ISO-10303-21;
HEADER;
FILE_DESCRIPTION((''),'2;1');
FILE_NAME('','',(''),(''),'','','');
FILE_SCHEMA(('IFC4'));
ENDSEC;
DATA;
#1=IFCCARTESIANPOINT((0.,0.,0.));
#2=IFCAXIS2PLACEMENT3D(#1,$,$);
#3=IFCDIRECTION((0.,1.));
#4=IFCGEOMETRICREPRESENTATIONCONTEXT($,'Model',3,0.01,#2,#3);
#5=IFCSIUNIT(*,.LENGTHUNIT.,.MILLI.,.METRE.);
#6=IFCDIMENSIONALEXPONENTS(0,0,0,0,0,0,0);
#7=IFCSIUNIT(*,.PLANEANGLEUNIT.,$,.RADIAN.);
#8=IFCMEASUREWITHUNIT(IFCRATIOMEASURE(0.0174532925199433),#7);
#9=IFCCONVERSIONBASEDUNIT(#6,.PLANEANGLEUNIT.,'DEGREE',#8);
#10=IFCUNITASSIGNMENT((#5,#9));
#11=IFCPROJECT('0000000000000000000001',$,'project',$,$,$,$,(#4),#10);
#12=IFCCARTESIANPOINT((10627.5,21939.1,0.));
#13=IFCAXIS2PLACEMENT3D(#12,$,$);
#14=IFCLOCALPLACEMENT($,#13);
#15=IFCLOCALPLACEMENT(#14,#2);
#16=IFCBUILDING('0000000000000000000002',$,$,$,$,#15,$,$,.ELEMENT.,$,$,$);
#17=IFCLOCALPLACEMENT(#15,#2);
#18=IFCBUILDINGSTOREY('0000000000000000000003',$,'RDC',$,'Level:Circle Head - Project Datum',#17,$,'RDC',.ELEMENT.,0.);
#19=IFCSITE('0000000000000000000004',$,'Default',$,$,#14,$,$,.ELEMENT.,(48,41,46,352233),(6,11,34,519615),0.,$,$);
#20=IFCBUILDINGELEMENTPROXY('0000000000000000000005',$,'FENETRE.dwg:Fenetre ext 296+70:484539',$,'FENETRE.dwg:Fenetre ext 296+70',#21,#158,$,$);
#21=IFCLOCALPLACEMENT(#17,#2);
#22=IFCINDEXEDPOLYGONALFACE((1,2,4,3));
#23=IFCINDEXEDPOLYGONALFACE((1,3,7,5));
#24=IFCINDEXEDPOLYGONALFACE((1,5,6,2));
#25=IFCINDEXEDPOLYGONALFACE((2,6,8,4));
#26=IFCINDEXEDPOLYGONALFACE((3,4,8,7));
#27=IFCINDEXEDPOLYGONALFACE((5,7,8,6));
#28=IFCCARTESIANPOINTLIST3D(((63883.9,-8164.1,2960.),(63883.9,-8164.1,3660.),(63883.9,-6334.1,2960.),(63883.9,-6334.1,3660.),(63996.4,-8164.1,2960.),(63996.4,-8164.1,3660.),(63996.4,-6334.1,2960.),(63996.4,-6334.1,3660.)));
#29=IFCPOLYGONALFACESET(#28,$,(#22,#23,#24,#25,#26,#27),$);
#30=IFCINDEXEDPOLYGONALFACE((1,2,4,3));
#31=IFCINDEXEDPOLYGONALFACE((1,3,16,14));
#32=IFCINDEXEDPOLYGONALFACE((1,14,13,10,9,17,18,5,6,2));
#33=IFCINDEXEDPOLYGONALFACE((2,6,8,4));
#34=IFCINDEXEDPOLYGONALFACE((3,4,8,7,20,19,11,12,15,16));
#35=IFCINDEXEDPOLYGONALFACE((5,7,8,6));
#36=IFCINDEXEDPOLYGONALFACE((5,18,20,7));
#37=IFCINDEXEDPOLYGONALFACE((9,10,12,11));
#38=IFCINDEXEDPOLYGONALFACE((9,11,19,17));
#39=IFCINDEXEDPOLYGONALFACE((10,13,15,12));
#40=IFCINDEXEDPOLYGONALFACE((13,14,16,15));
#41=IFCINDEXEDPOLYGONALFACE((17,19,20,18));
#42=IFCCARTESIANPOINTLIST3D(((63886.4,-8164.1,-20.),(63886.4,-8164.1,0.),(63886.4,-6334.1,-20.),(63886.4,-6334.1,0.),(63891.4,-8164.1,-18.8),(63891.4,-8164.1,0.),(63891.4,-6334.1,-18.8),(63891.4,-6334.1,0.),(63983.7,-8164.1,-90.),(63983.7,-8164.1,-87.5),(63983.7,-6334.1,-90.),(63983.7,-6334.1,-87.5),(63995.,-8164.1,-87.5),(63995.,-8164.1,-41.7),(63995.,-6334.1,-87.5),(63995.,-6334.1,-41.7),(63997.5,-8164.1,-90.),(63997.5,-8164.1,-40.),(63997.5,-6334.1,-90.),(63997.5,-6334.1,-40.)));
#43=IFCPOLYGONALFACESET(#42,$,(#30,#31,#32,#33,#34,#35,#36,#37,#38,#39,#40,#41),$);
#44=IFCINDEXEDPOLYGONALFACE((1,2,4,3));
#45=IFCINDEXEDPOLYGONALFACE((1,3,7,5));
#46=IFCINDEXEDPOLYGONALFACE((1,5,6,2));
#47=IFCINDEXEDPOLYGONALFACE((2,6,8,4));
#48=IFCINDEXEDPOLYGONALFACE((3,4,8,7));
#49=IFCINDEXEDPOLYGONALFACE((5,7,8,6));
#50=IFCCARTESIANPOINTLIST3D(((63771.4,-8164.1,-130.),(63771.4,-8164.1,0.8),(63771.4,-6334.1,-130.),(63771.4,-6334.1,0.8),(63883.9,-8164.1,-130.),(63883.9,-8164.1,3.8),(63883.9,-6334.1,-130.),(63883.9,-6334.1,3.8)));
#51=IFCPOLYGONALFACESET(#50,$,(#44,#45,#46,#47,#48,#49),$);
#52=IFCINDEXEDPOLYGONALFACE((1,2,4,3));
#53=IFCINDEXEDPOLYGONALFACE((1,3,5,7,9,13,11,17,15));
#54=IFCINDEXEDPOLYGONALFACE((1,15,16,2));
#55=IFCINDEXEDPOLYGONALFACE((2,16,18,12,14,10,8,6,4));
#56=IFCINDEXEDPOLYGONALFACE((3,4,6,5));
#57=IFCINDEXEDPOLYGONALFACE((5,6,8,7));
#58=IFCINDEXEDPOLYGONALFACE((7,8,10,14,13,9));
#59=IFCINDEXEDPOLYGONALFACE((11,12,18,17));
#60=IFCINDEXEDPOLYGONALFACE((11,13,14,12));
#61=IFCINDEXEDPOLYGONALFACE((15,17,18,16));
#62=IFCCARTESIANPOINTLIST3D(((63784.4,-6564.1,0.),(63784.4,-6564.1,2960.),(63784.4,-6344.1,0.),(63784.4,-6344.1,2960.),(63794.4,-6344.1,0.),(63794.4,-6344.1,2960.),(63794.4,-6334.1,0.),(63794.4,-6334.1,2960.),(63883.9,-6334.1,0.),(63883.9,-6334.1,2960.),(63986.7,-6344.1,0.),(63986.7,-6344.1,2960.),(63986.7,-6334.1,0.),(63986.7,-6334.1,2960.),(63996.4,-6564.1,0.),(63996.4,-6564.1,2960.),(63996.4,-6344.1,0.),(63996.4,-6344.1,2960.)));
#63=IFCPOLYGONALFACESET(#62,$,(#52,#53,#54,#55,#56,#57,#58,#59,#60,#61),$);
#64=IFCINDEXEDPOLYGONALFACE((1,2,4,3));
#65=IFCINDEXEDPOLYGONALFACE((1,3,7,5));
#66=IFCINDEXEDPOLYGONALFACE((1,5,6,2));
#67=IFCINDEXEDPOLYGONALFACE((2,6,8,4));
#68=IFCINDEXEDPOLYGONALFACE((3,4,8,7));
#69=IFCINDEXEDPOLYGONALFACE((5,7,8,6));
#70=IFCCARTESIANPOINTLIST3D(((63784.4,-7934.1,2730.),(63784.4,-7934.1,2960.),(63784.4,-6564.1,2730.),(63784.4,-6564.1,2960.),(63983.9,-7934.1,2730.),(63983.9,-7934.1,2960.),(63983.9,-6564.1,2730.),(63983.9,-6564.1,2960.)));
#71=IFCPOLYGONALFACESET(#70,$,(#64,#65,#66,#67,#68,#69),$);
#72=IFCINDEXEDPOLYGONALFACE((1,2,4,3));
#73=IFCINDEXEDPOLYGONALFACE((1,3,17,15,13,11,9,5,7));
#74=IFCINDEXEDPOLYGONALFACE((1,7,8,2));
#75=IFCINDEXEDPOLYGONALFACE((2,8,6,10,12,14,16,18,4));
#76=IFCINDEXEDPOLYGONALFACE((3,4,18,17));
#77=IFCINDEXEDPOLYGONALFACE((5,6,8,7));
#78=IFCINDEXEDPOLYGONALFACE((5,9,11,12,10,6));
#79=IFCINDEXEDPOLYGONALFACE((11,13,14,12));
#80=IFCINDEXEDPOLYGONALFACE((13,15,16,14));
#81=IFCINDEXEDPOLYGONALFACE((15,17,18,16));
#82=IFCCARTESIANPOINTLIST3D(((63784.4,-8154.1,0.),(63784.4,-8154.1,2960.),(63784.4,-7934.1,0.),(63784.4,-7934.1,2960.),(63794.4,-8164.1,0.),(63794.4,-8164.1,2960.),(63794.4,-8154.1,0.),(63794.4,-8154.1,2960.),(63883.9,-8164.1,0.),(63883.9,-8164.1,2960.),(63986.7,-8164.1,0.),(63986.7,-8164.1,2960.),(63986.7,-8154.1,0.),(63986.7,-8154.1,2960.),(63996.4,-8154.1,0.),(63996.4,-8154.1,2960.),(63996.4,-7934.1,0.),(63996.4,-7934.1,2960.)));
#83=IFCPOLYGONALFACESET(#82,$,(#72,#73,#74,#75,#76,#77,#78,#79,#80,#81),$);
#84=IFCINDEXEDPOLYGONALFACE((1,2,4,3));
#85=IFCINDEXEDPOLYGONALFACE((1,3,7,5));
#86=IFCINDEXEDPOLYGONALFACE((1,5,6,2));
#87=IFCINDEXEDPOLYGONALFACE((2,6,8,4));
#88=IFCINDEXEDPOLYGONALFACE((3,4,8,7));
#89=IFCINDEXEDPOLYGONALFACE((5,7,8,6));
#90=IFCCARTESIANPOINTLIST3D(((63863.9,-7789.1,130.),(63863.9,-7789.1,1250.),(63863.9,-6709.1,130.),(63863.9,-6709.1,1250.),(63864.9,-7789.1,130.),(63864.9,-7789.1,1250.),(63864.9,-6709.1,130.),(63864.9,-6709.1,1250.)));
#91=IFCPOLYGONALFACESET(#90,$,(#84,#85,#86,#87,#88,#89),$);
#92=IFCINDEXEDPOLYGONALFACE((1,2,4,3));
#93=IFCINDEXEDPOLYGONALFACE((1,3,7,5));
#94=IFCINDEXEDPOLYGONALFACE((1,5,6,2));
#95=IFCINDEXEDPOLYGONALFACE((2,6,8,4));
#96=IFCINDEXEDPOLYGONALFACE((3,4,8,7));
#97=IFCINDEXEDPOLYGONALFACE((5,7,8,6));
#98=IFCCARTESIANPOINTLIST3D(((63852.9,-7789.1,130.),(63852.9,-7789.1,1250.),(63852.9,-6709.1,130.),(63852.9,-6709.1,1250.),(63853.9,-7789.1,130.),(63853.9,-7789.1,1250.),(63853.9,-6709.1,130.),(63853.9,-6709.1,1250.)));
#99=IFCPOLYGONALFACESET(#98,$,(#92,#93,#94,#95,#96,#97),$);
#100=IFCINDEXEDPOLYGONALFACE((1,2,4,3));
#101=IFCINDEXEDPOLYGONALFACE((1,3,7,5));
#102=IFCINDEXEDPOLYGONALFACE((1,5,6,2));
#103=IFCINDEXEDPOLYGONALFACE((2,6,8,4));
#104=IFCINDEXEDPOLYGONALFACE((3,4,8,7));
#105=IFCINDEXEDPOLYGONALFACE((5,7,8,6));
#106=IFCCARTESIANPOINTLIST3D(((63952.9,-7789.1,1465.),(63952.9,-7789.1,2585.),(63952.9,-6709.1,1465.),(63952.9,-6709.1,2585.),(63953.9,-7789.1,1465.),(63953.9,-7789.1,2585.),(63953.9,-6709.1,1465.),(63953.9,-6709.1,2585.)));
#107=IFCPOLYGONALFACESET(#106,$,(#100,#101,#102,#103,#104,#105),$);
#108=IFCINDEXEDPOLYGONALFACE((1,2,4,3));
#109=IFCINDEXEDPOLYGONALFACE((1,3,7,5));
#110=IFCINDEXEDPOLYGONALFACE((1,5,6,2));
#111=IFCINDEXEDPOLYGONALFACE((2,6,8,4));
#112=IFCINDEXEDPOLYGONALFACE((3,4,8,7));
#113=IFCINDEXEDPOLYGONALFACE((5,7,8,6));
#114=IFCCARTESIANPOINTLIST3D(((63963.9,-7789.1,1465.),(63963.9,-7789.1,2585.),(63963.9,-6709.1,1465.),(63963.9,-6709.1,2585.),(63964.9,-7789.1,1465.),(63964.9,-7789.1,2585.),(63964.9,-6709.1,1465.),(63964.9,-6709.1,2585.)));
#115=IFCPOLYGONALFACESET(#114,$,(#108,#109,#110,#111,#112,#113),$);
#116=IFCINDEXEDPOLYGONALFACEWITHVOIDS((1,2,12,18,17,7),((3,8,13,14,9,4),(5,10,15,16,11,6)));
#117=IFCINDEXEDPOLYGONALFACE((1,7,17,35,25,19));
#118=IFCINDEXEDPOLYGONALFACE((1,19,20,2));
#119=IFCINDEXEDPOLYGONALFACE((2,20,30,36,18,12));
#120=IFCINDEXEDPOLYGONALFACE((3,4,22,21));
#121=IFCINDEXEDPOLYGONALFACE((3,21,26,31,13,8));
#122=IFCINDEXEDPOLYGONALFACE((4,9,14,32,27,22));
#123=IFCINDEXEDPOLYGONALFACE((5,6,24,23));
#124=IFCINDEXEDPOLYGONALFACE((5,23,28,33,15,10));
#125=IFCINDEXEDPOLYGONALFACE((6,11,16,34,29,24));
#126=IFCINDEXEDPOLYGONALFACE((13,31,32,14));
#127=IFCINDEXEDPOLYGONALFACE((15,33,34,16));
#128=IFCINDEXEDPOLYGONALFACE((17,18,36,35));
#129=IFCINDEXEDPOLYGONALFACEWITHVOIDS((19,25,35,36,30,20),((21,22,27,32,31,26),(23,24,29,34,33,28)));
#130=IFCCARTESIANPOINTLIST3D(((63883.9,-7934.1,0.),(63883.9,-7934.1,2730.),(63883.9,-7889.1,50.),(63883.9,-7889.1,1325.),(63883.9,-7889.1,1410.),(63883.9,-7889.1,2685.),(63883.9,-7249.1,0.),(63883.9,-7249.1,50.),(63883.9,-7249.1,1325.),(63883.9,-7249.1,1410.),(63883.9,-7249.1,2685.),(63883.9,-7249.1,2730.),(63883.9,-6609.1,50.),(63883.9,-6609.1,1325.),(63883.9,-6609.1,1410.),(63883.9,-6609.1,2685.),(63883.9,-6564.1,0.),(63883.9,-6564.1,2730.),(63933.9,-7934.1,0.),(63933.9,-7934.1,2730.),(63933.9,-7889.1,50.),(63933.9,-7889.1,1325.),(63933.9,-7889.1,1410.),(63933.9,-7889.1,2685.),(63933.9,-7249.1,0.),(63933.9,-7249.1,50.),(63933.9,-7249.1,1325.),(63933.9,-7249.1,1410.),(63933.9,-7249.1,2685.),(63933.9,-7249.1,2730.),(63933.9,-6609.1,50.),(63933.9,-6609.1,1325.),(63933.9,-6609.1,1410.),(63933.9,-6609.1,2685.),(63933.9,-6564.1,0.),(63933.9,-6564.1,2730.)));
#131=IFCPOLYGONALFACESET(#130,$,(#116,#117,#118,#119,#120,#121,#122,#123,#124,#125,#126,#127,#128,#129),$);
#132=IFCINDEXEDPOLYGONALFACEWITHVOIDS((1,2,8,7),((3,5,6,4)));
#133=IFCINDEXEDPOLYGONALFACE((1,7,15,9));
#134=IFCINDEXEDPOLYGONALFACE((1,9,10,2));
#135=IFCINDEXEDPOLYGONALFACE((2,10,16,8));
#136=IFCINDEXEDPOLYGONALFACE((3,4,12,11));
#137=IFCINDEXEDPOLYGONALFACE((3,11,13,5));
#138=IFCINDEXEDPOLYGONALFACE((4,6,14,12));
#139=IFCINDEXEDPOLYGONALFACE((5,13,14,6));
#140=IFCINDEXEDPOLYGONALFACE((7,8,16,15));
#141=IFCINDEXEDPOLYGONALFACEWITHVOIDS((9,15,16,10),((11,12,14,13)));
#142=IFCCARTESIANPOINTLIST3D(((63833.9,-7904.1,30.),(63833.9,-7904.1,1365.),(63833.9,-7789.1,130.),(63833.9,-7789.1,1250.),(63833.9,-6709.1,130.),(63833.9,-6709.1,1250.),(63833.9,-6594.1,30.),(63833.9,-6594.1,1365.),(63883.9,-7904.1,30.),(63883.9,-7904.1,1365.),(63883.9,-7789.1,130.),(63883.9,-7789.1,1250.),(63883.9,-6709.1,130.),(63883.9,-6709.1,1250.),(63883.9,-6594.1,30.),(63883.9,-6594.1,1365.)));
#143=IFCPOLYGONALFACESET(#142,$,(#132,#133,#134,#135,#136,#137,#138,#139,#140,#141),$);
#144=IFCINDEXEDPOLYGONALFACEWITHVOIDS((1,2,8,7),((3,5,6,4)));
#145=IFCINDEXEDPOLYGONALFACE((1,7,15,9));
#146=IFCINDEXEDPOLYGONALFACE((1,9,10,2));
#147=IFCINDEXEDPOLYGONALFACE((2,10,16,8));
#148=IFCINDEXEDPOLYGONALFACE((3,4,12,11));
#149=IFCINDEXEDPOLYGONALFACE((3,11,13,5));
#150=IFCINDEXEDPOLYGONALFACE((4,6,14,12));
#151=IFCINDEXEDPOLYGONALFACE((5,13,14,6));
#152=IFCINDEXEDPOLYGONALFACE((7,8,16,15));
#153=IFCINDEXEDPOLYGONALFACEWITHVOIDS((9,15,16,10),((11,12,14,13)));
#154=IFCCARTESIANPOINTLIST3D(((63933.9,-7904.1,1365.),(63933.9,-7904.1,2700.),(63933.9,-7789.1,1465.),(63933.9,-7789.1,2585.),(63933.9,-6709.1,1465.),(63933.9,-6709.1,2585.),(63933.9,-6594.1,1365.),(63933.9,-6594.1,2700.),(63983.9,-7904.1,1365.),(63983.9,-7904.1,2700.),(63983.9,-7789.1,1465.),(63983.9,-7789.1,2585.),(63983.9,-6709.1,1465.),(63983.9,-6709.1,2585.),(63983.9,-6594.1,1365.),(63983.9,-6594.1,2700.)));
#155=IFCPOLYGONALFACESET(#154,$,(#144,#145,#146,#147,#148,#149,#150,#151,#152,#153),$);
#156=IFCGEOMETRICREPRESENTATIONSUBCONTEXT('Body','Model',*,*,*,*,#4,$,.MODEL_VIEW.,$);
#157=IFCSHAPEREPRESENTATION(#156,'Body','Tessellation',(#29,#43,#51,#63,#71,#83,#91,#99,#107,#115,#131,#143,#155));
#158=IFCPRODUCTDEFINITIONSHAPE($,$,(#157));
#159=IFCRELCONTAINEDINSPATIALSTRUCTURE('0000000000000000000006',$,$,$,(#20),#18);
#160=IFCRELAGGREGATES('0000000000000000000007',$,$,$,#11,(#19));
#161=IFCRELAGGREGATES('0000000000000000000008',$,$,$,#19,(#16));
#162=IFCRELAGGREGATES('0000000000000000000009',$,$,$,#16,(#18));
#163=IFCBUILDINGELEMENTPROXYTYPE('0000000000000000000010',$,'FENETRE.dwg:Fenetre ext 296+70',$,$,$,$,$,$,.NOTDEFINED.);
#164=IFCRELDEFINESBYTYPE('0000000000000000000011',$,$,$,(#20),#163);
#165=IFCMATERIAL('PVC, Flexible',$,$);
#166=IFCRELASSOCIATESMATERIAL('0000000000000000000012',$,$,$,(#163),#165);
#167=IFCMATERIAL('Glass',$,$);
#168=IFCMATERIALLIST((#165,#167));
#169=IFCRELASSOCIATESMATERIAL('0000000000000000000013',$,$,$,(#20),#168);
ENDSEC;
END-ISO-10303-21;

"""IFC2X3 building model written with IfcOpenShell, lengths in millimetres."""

from ifc_helpers import new_model, entity, si_unit, converted_unit, direction, frame, frame_2d, origin, origin_2d_with_axis, place, context, subcontext, project, spatial, polyline, rectangle, outline, extrude, source, transform, mapped, material, material_list, type_object, type_shapes, element, save


model = new_model("IFC2X3")

# Units and contexts
model_context = context("Model", 3, precision=0.01, world=origin(), true_north=direction((0.0, 1.0)))
body_context = subcontext(model_context, "Body", "Model", "MODEL_VIEW")
ifc_project = project(units=[si_unit("LENGTHUNIT", "METRE", prefix="MILLI"), converted_unit("PLANEANGLEUNIT", "DEGREE", entity("IfcRatioMeasure", 0.0174532925199433), si_unit("PLANEANGLEUNIT", "RADIAN"), dimensions=[0, 0, 0, 0, 0, 0, 0])], contexts=[model_context])

# Site, building, storey
site_placement = place(None, frame((10627.5, 21939.1, 0.0)))
site = spatial("IfcSite", under=ifc_project, at=site_placement, Name="Default", CompositionType="ELEMENT", RefLatitude=(48, 41, 46, 352233), RefLongitude=(6, 11, 34, 519615), RefElevation=0.0)
building_placement = place(site_placement, origin())
building = spatial("IfcBuilding", under=site, at=building_placement, CompositionType="ELEMENT")
storey_placement = place(building_placement, origin())
storey = spatial("IfcBuildingStorey", under=building, at=storey_placement, Name="RDC", ObjectType="Level:Circle Head - Project Datum", LongName="RDC", CompositionType="ELEMENT", Elevation=0.0)

# Building element proxy
ifc_material_1 = material(Name="PVC, Flexible")
ifc_material_2 = material(Name="Glass")
building_element_proxy_type_1 = type_object("IfcBuildingElementProxyType", Name="FENETRE.dwg:Fenetre ext 296+70", PredefinedType="NOTDEFINED", material=ifc_material_1)
shared_shape_1 = source(origin(), body_context, "Body", "SweptSolid", [
    extrude(rectangle(XDim=112.5, YDim=1830.0, at=origin_2d_with_axis()), frame((-10.4, -56.3, 2960.0), z_axis=(0.0, 0.0, 1.0), x_axis=(0.0, 1.0, 0.0)), (0.0, 0.0, 1.0), 700.0),
    extrude(outline(polyline([(27.5, -64.4), (47.5, -64.4), (47.5, -59.4), (28.8, -59.4), (7.5, 46.7), (-42.5, 46.7), (-42.5, 32.9), (-40.0, 32.9), (-40.0, 44.2), (5.8, 44.2), (27.5, -64.4)])), frame((-925.4, -66.9, -47.5), z_axis=(1.0, 0.0, 0.0), x_axis=(0.0, 0.0, 1.0)), (0.0, 0.0, 1.0), 1830.0),
    extrude(outline(polyline([(-54.5, -66.1), (58.0, -66.1), (54.5, 67.6), (-58.0, 64.6), (-54.5, -66.1)])), frame((-925.4, 56.3, -63.8), z_axis=(1.0, 0.0, 0.0), x_axis=(0.0, -0.999645, 0.02665)), (0.0, 0.0, 1.0), 1830.0),
    extrude(outline(polyline([(-97.0, -55.6), (5.9, -55.6), (95.4, -55.6), (95.4, -45.6), (105.4, -45.6), (105.4, 174.4), (-106.6, 174.4), (-106.6, -45.6), (-97.0, -45.6), (-97.0, -55.6)])), frame((849.0, -5.9, 0.0), z_axis=(0.0, 0.0, 1.0), x_axis=(0.0, 1.0, 0.0)), (0.0, 0.0, 1.0), 2960.0),
    extrude(rectangle(XDim=1370.0, YDim=199.5, at=origin_2d_with_axis()), frame((-10.4, -0.3, 2730.0), z_axis=(0.0, 0.0, 1.0), x_axis=(-1.0, 0.0, 0.0)), (0.0, 0.0, 1.0), 230.0),
    extrude(outline(polyline([(-55.6, 97.0), (-55.6, -5.9), (-55.6, -95.4), (-45.6, -95.4), (-45.6, -105.4), (174.4, -105.4), (174.4, 106.6), (-45.6, 106.6), (-45.6, 97.0), (-55.6, 97.0)])), frame((-869.9, -5.9, 0.0), z_axis=(0.0, 0.0, -1.0), x_axis=(1.0, 0.0, 0.0)), (0.0, 0.0, -1.0), 2960.0),
    extrude(rectangle(XDim=1080.0, YDim=1.0, at=origin_2d_with_axis()), frame((-10.4, 19.5, 130.0), z_axis=(0.0, 0.0, 1.0), x_axis=(-1.0, 0.0, 0.0)), (0.0, 0.0, 1.0), 1120.0),
    extrude(rectangle(XDim=1080.0, YDim=1.0, at=origin_2d_with_axis()), frame((-10.4, 30.5, 130.0), z_axis=(0.0, 0.0, 1.0), x_axis=(-1.0, 0.0, 0.0)), (0.0, 0.0, 1.0), 1120.0),
    extrude(rectangle(XDim=1080.0, YDim=1.0, at=frame_2d((0.0, 0.0), x_axis=(1.0, 0.0))), frame((-10.4, -69.5, 1465.0), z_axis=(0.0, 0.0, 1.0), x_axis=(-1.0, 0.0, 0.0)), (0.0, 0.0, 1.0), 1120.0),
    extrude(rectangle(XDim=1080.0, YDim=1.0, at=frame_2d((0.0, 0.0), x_axis=(1.0, 0.0))), frame((-10.4, -80.5, 1465.0), z_axis=(0.0, 0.0, 1.0), x_axis=(-1.0, 0.0, 0.0)), (0.0, 0.0, 1.0), 1120.0),
    extrude(outline(polyline([(-685.0, -1365.0), (0.0, -1365.0), (685.0, -1365.0), (685.0, 1365.0), (0.0, 1365.0), (-685.0, 1365.0), (-685.0, -1365.0)]), holes=[polyline([(-640.0, -1320.0), (-640.0, -45.0), (0.0, -45.0), (640.0, -45.0), (640.0, -1320.0), (0.0, -1320.0), (-640.0, -1320.0)]), polyline([(-640.0, 40.0), (-640.0, 1315.0), (0.0, 1315.0), (640.0, 1315.0), (640.0, 40.0), (0.0, 40.0), (-640.0, 40.0)])]), frame((-10.4, -50.0, 1365.0), z_axis=(0.0, 1.0, 0.0), x_axis=(1.0, 0.0, 0.0)), (0.0, 0.0, 1.0), 50.0),
    extrude(outline(polyline([(-655.0, -667.5), (655.0, -667.5), (655.0, 667.5), (-655.0, 667.5), (-655.0, -667.5)]), holes=[polyline([(-540.0, 552.5), (540.0, 552.5), (540.0, -567.5), (-540.0, -567.5), (-540.0, 552.5)])]), frame((-10.4, 0.0, 697.5), z_axis=(0.0, 1.0, 0.0), x_axis=(-1.0, 0.0, 0.0)), (0.0, 0.0, 1.0), 50.0),
    extrude(outline(polyline([(-655.0, -667.5), (655.0, -667.5), (655.0, 667.5), (-655.0, 667.5), (-655.0, -667.5)]), holes=[polyline([(-540.0, 552.5), (540.0, 552.5), (540.0, -567.5), (-540.0, -567.5), (-540.0, 552.5)])]), frame((-10.4, -100.0, 2032.5), z_axis=(0.0, 1.0, 0.0), x_axis=(-1.0, 0.0, 0.0)), (0.0, 0.0, 1.0), 50.0),
])
type_shapes(building_element_proxy_type_1, [shared_shape_1])
ifc_material_list_1 = material_list([ifc_material_1, ifc_material_2])
proxy_1_placement = place(storey_placement, frame((63883.9, -7238.7, 0.0), z_axis=(0.0, 0.0, 1.0), x_axis=(0.0, 1.0, 0.0)))
element("IfcBuildingElementProxy", 1, at=proxy_1_placement, inside=storey, type_object=building_element_proxy_type_1, material=ifc_material_list_1, Name="FENETRE.dwg:Fenetre ext 296+70:484539", ObjectType="FENETRE.dwg:Fenetre ext 296+70", context=body_context, shape_type="MappedRepresentation", body=[
    mapped(shared_shape_1, transform((0.0, 0.0, 0.0), scale=1.0)),
])

save(model, "model.ifc")
